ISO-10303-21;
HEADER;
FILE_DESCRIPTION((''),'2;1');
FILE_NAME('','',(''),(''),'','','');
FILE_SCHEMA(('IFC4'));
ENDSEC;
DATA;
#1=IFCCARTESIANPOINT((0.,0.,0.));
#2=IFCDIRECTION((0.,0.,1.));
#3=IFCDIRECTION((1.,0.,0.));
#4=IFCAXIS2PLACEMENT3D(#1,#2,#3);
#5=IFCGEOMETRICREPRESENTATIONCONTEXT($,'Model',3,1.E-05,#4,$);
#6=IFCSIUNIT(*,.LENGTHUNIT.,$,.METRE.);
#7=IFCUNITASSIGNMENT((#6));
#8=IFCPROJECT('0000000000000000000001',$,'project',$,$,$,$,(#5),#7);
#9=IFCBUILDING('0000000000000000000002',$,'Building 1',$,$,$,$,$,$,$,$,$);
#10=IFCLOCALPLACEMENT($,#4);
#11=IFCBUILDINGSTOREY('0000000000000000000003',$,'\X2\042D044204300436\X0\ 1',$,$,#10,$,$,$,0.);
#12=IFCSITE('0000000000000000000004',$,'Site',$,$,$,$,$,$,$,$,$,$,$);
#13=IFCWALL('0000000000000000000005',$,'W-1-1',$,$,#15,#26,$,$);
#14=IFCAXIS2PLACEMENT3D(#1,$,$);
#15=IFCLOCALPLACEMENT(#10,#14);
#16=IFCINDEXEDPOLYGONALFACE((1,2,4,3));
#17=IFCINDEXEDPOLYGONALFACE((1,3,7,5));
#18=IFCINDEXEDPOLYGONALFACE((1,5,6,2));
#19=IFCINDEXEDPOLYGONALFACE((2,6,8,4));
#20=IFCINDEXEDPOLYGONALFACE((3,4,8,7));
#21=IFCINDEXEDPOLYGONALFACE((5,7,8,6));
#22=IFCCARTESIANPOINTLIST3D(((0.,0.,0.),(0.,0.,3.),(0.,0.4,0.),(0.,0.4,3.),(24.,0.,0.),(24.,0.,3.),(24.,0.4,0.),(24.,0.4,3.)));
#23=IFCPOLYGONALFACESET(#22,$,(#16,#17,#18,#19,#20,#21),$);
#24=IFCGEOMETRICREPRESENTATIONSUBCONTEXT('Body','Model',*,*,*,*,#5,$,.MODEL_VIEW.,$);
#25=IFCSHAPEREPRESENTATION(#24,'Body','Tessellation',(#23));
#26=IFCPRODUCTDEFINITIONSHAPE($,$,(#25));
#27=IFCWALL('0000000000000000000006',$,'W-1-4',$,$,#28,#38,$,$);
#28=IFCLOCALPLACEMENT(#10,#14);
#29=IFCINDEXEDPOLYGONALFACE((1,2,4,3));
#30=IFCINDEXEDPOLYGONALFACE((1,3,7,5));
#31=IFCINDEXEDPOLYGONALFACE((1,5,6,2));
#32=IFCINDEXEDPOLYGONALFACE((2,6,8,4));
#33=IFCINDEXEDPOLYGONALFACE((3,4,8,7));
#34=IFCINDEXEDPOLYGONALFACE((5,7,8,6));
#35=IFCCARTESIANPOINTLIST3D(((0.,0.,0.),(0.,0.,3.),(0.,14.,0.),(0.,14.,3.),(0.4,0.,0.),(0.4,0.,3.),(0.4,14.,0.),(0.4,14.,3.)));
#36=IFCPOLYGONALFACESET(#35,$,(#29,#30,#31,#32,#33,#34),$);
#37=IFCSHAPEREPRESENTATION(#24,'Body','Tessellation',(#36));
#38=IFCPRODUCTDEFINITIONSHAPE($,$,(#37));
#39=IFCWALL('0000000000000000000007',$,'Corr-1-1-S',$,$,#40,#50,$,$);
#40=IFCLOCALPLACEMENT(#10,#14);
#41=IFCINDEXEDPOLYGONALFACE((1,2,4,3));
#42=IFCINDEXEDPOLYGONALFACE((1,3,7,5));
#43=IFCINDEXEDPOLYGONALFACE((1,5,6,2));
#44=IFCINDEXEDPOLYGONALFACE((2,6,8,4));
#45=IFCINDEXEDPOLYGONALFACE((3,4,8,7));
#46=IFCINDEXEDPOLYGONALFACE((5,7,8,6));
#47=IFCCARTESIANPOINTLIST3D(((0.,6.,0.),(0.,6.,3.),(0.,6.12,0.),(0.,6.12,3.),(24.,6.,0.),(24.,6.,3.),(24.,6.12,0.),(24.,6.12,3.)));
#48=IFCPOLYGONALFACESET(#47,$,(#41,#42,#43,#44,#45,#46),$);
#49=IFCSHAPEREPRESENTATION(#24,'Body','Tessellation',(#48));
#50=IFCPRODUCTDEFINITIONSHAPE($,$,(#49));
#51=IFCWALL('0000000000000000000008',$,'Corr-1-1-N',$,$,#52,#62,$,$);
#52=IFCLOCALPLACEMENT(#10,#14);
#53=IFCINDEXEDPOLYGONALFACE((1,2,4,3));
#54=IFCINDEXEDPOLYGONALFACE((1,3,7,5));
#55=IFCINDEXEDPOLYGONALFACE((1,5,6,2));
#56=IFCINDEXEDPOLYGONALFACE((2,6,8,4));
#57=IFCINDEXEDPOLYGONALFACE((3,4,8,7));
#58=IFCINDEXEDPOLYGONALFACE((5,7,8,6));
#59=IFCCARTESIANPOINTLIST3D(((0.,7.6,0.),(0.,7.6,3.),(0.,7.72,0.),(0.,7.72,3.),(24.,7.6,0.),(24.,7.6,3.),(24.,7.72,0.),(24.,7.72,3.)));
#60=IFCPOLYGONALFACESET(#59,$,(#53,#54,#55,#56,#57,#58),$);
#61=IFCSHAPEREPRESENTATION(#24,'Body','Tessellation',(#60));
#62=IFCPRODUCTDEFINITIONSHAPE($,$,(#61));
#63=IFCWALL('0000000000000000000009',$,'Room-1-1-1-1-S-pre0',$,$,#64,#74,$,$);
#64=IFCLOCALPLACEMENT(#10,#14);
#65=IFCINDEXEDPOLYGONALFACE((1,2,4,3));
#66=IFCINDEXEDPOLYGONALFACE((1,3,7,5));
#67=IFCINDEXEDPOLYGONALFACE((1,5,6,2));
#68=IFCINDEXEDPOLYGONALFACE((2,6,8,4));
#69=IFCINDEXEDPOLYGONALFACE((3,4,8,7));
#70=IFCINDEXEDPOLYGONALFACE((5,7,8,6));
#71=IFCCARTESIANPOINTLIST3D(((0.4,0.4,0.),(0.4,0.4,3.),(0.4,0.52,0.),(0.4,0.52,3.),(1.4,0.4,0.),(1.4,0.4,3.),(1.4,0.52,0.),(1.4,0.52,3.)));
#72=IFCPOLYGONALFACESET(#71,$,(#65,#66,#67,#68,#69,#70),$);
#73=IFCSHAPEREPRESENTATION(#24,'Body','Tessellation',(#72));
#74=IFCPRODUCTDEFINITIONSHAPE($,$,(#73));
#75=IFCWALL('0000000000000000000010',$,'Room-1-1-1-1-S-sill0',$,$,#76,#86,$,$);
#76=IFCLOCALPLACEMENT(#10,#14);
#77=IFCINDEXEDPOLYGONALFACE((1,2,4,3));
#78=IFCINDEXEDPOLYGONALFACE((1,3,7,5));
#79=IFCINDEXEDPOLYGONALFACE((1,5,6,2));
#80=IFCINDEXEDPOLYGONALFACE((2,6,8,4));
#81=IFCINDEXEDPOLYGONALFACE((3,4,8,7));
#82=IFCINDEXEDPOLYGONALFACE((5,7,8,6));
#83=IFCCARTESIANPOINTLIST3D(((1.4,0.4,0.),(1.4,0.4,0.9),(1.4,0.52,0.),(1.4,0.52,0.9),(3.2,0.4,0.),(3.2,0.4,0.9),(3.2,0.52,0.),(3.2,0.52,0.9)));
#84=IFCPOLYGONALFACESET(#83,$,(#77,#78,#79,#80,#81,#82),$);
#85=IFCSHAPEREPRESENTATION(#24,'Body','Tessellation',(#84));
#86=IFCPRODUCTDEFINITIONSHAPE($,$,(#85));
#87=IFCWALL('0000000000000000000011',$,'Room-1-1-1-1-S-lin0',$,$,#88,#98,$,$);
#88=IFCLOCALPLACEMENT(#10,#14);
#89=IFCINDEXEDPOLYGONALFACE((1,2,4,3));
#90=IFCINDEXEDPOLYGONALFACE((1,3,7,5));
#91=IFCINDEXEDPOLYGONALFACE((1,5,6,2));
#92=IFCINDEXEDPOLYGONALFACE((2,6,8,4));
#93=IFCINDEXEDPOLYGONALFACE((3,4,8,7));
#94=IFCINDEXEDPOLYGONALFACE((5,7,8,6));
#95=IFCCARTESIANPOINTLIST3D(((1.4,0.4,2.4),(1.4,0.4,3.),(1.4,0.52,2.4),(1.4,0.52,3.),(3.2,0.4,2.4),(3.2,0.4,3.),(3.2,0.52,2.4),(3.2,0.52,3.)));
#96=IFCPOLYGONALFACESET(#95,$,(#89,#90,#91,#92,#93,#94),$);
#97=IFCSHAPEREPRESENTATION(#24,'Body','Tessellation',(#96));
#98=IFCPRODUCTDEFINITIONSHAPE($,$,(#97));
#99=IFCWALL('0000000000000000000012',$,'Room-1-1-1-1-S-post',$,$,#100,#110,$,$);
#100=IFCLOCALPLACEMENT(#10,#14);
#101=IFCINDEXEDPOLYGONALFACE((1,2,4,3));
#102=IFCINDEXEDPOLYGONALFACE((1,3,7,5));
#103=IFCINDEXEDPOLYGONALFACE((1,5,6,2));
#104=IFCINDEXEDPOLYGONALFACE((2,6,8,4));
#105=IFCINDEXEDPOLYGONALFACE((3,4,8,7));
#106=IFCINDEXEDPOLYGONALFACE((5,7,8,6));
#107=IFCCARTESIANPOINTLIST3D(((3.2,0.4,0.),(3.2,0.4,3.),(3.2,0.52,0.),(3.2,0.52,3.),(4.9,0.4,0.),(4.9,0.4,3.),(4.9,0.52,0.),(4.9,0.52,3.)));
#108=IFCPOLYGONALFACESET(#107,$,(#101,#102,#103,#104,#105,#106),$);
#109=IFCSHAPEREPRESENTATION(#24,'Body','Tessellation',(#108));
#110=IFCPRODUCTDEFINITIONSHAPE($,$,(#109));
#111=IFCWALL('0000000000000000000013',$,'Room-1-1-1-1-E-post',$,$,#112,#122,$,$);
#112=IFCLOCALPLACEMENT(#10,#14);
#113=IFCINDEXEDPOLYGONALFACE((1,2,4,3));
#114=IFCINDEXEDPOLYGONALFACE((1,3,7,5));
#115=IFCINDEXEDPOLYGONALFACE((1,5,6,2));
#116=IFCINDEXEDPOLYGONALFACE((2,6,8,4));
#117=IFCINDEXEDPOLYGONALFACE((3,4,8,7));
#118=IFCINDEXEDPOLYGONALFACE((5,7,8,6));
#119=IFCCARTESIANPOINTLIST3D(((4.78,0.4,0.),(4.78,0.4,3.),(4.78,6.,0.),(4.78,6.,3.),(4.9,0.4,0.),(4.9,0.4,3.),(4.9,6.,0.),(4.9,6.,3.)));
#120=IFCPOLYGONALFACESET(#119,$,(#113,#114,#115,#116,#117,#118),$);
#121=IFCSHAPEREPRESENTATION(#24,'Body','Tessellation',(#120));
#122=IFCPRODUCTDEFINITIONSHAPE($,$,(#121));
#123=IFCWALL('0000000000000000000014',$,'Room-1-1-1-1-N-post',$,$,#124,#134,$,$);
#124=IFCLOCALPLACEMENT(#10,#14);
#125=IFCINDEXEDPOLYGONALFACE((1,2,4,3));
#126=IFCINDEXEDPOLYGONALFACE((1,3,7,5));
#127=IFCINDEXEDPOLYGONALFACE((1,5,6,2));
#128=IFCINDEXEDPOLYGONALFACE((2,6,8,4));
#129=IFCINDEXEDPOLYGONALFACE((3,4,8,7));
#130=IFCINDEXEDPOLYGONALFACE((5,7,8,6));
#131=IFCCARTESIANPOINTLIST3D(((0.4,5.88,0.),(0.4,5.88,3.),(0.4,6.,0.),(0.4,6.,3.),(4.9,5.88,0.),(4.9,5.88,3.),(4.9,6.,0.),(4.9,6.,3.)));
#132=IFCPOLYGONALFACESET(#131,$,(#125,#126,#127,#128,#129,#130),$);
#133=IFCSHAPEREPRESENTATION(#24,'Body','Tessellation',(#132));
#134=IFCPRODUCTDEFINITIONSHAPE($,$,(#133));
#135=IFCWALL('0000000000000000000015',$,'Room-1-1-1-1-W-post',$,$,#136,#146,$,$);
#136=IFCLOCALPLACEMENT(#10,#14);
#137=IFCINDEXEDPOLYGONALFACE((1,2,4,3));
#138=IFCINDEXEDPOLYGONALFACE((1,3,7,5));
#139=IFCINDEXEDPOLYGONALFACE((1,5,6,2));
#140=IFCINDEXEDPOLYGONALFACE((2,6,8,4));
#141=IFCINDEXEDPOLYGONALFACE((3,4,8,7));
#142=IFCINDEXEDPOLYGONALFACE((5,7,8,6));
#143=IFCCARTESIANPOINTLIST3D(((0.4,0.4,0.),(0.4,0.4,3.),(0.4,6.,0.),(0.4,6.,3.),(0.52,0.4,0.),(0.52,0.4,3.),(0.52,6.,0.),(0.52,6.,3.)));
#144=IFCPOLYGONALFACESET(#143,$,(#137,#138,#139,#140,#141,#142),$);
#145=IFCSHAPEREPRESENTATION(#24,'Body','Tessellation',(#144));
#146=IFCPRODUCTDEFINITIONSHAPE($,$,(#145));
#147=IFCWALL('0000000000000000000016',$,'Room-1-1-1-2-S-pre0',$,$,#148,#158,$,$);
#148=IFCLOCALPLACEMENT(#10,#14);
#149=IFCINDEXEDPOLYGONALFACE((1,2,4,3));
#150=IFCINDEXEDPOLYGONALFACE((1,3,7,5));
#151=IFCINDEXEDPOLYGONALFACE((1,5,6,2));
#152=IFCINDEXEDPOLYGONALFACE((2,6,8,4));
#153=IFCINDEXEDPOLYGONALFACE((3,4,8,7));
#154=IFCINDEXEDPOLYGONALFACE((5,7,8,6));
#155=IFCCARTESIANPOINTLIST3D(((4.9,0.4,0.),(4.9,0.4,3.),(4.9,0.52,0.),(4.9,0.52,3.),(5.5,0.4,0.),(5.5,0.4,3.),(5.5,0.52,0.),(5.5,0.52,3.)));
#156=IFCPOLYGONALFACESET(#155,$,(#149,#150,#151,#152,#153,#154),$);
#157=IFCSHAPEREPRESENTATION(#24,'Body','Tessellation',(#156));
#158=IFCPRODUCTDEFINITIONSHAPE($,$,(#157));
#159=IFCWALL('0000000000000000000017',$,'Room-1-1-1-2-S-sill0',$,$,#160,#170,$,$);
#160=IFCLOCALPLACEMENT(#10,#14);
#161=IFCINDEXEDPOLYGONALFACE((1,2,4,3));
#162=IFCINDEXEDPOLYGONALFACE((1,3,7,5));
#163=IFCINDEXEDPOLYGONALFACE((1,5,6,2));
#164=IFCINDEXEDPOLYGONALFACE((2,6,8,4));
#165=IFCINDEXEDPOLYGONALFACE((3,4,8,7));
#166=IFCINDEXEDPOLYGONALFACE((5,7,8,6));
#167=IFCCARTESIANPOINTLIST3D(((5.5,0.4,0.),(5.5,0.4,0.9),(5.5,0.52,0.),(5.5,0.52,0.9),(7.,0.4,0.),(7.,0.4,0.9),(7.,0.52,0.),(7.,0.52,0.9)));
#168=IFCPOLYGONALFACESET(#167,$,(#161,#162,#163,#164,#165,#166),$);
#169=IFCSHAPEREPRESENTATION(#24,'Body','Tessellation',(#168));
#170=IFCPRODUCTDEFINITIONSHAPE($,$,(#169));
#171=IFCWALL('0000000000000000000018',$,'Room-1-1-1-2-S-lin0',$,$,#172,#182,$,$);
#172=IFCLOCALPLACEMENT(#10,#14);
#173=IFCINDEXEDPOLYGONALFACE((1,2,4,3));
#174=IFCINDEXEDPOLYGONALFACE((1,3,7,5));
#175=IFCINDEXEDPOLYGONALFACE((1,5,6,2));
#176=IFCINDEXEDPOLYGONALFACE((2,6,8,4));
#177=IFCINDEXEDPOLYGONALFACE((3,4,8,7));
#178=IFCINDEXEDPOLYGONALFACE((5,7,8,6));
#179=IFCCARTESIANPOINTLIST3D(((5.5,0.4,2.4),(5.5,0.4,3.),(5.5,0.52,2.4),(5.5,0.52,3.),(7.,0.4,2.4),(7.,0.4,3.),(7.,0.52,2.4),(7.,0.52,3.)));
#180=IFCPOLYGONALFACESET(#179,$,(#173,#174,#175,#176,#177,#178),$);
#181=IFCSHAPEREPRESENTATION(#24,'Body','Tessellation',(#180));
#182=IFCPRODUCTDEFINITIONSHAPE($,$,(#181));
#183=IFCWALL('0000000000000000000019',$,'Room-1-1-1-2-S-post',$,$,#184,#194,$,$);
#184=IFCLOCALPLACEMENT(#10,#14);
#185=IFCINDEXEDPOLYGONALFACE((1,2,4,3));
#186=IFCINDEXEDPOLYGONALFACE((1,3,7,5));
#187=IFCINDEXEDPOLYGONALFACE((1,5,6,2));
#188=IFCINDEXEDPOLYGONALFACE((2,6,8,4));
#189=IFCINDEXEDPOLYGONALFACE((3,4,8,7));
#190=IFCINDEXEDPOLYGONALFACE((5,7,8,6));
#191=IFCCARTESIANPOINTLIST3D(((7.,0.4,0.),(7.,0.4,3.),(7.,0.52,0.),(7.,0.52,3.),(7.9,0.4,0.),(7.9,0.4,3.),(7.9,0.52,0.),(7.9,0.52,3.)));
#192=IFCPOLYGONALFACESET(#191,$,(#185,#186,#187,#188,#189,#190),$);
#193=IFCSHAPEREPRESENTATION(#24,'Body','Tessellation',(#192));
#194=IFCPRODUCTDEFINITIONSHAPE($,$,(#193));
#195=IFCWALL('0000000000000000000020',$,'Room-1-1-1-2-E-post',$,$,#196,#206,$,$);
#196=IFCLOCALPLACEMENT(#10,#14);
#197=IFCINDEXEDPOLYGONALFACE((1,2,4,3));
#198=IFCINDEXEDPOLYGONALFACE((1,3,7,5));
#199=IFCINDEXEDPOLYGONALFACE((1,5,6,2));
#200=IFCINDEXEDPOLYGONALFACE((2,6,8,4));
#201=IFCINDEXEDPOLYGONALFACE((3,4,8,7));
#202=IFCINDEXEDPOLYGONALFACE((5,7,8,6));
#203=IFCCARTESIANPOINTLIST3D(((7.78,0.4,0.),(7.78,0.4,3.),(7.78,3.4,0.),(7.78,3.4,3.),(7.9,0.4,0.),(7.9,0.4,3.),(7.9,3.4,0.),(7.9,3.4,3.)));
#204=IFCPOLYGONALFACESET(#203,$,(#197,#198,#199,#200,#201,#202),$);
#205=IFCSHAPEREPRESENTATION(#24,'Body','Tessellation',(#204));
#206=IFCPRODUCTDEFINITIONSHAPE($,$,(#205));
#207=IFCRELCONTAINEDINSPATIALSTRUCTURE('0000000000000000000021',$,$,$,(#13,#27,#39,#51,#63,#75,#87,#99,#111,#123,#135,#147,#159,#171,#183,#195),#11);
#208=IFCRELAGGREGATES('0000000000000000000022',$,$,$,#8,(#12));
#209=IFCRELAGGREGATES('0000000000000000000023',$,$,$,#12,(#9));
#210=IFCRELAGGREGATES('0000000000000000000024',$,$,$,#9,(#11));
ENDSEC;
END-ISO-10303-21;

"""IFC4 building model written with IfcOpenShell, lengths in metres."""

from ifc_helpers import new_model, si_unit, frame, origin_with_axes, place, context, subcontext, project, spatial, indexed_curve, outline, extrude, element, save


model = new_model("IFC4")

# Units and contexts
model_context = context("Model", 3, precision=1e-05, world=origin_with_axes())
body_context = subcontext(model_context, "Body", "Model", "MODEL_VIEW")
ifc_project = project(units=[si_unit("LENGTHUNIT", "METRE")], contexts=[model_context])

# Site, building, storey
site = spatial("IfcSite", under=ifc_project, Name="Site")
building = spatial("IfcBuilding", under=site, Name="Building 1")
storey_placement = place(None, origin_with_axes())
storey = spatial("IfcBuildingStorey", under=building, at=storey_placement, Name="Этаж 1", Elevation=0.0)

# Walls
wall_1_placement = place(storey_placement, origin_with_axes())
element("IfcWall", 1, at=wall_1_placement, inside=storey, Name="W-1-1", context=body_context, shape_type="SweptSolid", body=[
    extrude(outline(indexed_curve([(0.0, 0.0), (0.0, 0.4), (24.0, 0.4), (24.0, 0.0), (0.0, 0.0)], self_intersect=False)), origin_with_axes(), (0.0, 0.0, 1.0), 3.0),
])
wall_2_placement = place(storey_placement, frame((0.0, 14.0, 0.0), z_axis=(0.0, 0.0, 1.0), x_axis=(0.0, -1.0, 0.0)))
element("IfcWall", 2, at=wall_2_placement, inside=storey, Name="W-1-4", context=body_context, shape_type="SweptSolid", body=[
    extrude(outline(indexed_curve([(0.0, 0.0), (0.0, 0.4), (14.0, 0.4), (14.0, 0.0), (0.0, 0.0)], self_intersect=False)), origin_with_axes(), (0.0, 0.0, 1.0), 3.0),
])
for number, where, z_axis, x_axis, name in (
    (3, (0.0, 6.0, 0.0), (0.0, 0.0, 1.0), (1.0, 0.0, 0.0), "Corr-1-1-S"),
    (4, (0.0, 7.6, 0.0), (0.0, 0.0, 1.0), (1.0, 0.0, 0.0), "Corr-1-1-N"),
):
    element("IfcWall", number, at=place(storey_placement, frame(where, z_axis=z_axis, x_axis=x_axis)), inside=storey, Name=name, context=body_context, shape_type="SweptSolid", body=[
        extrude(outline(indexed_curve([(0.0, 0.0), (0.0, 0.12), (24.0, 0.12), (24.0, 0.0), (0.0, 0.0)], self_intersect=False)), origin_with_axes(), (0.0, 0.0, 1.0), 3.0),
    ])
wall_3_placement = place(storey_placement, frame((0.4, 0.4, 0.0), z_axis=(0.0, 0.0, 1.0), x_axis=(1.0, 0.0, 0.0)))
element("IfcWall", 5, at=wall_3_placement, inside=storey, Name="Room-1-1-1-1-S-pre0", context=body_context, shape_type="SweptSolid", body=[
    extrude(outline(indexed_curve([(0.0, 0.0), (0.0, 0.12), (1.0, 0.12), (1.0, 0.0), (0.0, 0.0)], self_intersect=False)), origin_with_axes(), (0.0, 0.0, 1.0), 3.0),
])
wall_4_placement = place(storey_placement, frame((1.4, 0.4, 0.0), z_axis=(0.0, 0.0, 1.0), x_axis=(1.0, 0.0, 0.0)))
element("IfcWall", 6, at=wall_4_placement, inside=storey, Name="Room-1-1-1-1-S-sill0", context=body_context, shape_type="SweptSolid", body=[
    extrude(outline(indexed_curve([(0.0, 0.0), (0.0, 0.12), (1.8, 0.12), (1.8, 0.0), (0.0, 0.0)], self_intersect=False)), origin_with_axes(), (0.0, 0.0, 1.0), 0.9),
])
wall_5_placement = place(storey_placement, frame((1.4, 0.4, 2.4), z_axis=(0.0, 0.0, 1.0), x_axis=(1.0, 0.0, 0.0)))
element("IfcWall", 7, at=wall_5_placement, inside=storey, Name="Room-1-1-1-1-S-lin0", context=body_context, shape_type="SweptSolid", body=[
    extrude(outline(indexed_curve([(0.0, 0.0), (0.0, 0.12), (1.8, 0.12), (1.8, 0.0), (0.0, 0.0)], self_intersect=False)), origin_with_axes(), (0.0, 0.0, 1.0), 0.6),
])
wall_6_placement = place(storey_placement, frame((3.2, 0.4, 0.0), z_axis=(0.0, 0.0, 1.0), x_axis=(1.0, 0.0, 0.0)))
element("IfcWall", 8, at=wall_6_placement, inside=storey, Name="Room-1-1-1-1-S-post", context=body_context, shape_type="SweptSolid", body=[
    extrude(outline(indexed_curve([(0.0, 0.0), (0.0, 0.12), (1.7, 0.12), (1.7, 0.0), (0.0, 0.0)], self_intersect=False)), origin_with_axes(), (0.0, 0.0, 1.0), 3.0),
])
wall_7_placement = place(storey_placement, frame((4.9, 0.4, 0.0), z_axis=(0.0, 0.0, 1.0), x_axis=(0.0, 1.0, 0.0)))
element("IfcWall", 9, at=wall_7_placement, inside=storey, Name="Room-1-1-1-1-E-post", context=body_context, shape_type="SweptSolid", body=[
    extrude(outline(indexed_curve([(0.0, 0.0), (0.0, 0.12), (5.6, 0.12), (5.6, 0.0), (0.0, 0.0)], self_intersect=False)), origin_with_axes(), (0.0, 0.0, 1.0), 3.0),
])
wall_8_placement = place(storey_placement, frame((4.9, 6.0, 0.0), z_axis=(0.0, 0.0, 1.0), x_axis=(-1.0, 0.0, 0.0)))
element("IfcWall", 10, at=wall_8_placement, inside=storey, Name="Room-1-1-1-1-N-post", context=body_context, shape_type="SweptSolid", body=[
    extrude(outline(indexed_curve([(0.0, 0.0), (0.0, 0.12), (4.5, 0.12), (4.5, 0.0), (0.0, 0.0)], self_intersect=False)), origin_with_axes(), (0.0, 0.0, 1.0), 3.0),
])
wall_9_placement = place(storey_placement, frame((0.4, 6.0, 0.0), z_axis=(0.0, 0.0, 1.0), x_axis=(0.0, -1.0, 0.0)))
element("IfcWall", 11, at=wall_9_placement, inside=storey, Name="Room-1-1-1-1-W-post", context=body_context, shape_type="SweptSolid", body=[
    extrude(outline(indexed_curve([(0.0, 0.0), (0.0, 0.12), (5.6, 0.12), (5.6, 0.0), (0.0, 0.0)], self_intersect=False)), origin_with_axes(), (0.0, 0.0, 1.0), 3.0),
])
wall_10_placement = place(storey_placement, frame((4.9, 0.4, 0.0), z_axis=(0.0, 0.0, 1.0), x_axis=(1.0, 0.0, 0.0)))
element("IfcWall", 12, at=wall_10_placement, inside=storey, Name="Room-1-1-1-2-S-pre0", context=body_context, shape_type="SweptSolid", body=[
    extrude(outline(indexed_curve([(0.0, 0.0), (0.0, 0.12), (0.6, 0.12), (0.6, 0.0), (0.0, 0.0)], self_intersect=False)), origin_with_axes(), (0.0, 0.0, 1.0), 3.0),
])
wall_11_placement = place(storey_placement, frame((5.5, 0.4, 0.0), z_axis=(0.0, 0.0, 1.0), x_axis=(1.0, 0.0, 0.0)))
element("IfcWall", 13, at=wall_11_placement, inside=storey, Name="Room-1-1-1-2-S-sill0", context=body_context, shape_type="SweptSolid", body=[
    extrude(outline(indexed_curve([(0.0, 0.0), (0.0, 0.12), (1.5, 0.12), (1.5, 0.0), (0.0, 0.0)], self_intersect=False)), origin_with_axes(), (0.0, 0.0, 1.0), 0.9),
])
wall_12_placement = place(storey_placement, frame((5.5, 0.4, 2.4), z_axis=(0.0, 0.0, 1.0), x_axis=(1.0, 0.0, 0.0)))
element("IfcWall", 14, at=wall_12_placement, inside=storey, Name="Room-1-1-1-2-S-lin0", context=body_context, shape_type="SweptSolid", body=[
    extrude(outline(indexed_curve([(0.0, 0.0), (0.0, 0.12), (1.5, 0.12), (1.5, 0.0), (0.0, 0.0)], self_intersect=False)), origin_with_axes(), (0.0, 0.0, 1.0), 0.6),
])
wall_13_placement = place(storey_placement, frame((7.0, 0.4, 0.0), z_axis=(0.0, 0.0, 1.0), x_axis=(1.0, 0.0, 0.0)))
element("IfcWall", 15, at=wall_13_placement, inside=storey, Name="Room-1-1-1-2-S-post", context=body_context, shape_type="SweptSolid", body=[
    extrude(outline(indexed_curve([(0.0, 0.0), (0.0, 0.12), (0.9, 0.12), (0.9, 0.0), (0.0, 0.0)], self_intersect=False)), origin_with_axes(), (0.0, 0.0, 1.0), 3.0),
])
for number, where, z_axis, x_axis, name in (
    (16, (7.9, 0.4, 0.0), (0.0, 0.0, 1.0), (0.0, 1.0, 0.0), "Room-1-1-1-2-E-post"),
):
    element("IfcWall", number, at=place(storey_placement, frame(where, z_axis=z_axis, x_axis=x_axis)), inside=storey, Name=name, context=body_context, shape_type="SweptSolid", body=[
        extrude(outline(indexed_curve([(0.0, 0.0), (0.0, 0.12), (3.0, 0.12), (3.0, 0.0), (0.0, 0.0)], self_intersect=False)), origin_with_axes(), (0.0, 0.0, 1.0), 3.0),
    ])

save(model, "model.ifc")
